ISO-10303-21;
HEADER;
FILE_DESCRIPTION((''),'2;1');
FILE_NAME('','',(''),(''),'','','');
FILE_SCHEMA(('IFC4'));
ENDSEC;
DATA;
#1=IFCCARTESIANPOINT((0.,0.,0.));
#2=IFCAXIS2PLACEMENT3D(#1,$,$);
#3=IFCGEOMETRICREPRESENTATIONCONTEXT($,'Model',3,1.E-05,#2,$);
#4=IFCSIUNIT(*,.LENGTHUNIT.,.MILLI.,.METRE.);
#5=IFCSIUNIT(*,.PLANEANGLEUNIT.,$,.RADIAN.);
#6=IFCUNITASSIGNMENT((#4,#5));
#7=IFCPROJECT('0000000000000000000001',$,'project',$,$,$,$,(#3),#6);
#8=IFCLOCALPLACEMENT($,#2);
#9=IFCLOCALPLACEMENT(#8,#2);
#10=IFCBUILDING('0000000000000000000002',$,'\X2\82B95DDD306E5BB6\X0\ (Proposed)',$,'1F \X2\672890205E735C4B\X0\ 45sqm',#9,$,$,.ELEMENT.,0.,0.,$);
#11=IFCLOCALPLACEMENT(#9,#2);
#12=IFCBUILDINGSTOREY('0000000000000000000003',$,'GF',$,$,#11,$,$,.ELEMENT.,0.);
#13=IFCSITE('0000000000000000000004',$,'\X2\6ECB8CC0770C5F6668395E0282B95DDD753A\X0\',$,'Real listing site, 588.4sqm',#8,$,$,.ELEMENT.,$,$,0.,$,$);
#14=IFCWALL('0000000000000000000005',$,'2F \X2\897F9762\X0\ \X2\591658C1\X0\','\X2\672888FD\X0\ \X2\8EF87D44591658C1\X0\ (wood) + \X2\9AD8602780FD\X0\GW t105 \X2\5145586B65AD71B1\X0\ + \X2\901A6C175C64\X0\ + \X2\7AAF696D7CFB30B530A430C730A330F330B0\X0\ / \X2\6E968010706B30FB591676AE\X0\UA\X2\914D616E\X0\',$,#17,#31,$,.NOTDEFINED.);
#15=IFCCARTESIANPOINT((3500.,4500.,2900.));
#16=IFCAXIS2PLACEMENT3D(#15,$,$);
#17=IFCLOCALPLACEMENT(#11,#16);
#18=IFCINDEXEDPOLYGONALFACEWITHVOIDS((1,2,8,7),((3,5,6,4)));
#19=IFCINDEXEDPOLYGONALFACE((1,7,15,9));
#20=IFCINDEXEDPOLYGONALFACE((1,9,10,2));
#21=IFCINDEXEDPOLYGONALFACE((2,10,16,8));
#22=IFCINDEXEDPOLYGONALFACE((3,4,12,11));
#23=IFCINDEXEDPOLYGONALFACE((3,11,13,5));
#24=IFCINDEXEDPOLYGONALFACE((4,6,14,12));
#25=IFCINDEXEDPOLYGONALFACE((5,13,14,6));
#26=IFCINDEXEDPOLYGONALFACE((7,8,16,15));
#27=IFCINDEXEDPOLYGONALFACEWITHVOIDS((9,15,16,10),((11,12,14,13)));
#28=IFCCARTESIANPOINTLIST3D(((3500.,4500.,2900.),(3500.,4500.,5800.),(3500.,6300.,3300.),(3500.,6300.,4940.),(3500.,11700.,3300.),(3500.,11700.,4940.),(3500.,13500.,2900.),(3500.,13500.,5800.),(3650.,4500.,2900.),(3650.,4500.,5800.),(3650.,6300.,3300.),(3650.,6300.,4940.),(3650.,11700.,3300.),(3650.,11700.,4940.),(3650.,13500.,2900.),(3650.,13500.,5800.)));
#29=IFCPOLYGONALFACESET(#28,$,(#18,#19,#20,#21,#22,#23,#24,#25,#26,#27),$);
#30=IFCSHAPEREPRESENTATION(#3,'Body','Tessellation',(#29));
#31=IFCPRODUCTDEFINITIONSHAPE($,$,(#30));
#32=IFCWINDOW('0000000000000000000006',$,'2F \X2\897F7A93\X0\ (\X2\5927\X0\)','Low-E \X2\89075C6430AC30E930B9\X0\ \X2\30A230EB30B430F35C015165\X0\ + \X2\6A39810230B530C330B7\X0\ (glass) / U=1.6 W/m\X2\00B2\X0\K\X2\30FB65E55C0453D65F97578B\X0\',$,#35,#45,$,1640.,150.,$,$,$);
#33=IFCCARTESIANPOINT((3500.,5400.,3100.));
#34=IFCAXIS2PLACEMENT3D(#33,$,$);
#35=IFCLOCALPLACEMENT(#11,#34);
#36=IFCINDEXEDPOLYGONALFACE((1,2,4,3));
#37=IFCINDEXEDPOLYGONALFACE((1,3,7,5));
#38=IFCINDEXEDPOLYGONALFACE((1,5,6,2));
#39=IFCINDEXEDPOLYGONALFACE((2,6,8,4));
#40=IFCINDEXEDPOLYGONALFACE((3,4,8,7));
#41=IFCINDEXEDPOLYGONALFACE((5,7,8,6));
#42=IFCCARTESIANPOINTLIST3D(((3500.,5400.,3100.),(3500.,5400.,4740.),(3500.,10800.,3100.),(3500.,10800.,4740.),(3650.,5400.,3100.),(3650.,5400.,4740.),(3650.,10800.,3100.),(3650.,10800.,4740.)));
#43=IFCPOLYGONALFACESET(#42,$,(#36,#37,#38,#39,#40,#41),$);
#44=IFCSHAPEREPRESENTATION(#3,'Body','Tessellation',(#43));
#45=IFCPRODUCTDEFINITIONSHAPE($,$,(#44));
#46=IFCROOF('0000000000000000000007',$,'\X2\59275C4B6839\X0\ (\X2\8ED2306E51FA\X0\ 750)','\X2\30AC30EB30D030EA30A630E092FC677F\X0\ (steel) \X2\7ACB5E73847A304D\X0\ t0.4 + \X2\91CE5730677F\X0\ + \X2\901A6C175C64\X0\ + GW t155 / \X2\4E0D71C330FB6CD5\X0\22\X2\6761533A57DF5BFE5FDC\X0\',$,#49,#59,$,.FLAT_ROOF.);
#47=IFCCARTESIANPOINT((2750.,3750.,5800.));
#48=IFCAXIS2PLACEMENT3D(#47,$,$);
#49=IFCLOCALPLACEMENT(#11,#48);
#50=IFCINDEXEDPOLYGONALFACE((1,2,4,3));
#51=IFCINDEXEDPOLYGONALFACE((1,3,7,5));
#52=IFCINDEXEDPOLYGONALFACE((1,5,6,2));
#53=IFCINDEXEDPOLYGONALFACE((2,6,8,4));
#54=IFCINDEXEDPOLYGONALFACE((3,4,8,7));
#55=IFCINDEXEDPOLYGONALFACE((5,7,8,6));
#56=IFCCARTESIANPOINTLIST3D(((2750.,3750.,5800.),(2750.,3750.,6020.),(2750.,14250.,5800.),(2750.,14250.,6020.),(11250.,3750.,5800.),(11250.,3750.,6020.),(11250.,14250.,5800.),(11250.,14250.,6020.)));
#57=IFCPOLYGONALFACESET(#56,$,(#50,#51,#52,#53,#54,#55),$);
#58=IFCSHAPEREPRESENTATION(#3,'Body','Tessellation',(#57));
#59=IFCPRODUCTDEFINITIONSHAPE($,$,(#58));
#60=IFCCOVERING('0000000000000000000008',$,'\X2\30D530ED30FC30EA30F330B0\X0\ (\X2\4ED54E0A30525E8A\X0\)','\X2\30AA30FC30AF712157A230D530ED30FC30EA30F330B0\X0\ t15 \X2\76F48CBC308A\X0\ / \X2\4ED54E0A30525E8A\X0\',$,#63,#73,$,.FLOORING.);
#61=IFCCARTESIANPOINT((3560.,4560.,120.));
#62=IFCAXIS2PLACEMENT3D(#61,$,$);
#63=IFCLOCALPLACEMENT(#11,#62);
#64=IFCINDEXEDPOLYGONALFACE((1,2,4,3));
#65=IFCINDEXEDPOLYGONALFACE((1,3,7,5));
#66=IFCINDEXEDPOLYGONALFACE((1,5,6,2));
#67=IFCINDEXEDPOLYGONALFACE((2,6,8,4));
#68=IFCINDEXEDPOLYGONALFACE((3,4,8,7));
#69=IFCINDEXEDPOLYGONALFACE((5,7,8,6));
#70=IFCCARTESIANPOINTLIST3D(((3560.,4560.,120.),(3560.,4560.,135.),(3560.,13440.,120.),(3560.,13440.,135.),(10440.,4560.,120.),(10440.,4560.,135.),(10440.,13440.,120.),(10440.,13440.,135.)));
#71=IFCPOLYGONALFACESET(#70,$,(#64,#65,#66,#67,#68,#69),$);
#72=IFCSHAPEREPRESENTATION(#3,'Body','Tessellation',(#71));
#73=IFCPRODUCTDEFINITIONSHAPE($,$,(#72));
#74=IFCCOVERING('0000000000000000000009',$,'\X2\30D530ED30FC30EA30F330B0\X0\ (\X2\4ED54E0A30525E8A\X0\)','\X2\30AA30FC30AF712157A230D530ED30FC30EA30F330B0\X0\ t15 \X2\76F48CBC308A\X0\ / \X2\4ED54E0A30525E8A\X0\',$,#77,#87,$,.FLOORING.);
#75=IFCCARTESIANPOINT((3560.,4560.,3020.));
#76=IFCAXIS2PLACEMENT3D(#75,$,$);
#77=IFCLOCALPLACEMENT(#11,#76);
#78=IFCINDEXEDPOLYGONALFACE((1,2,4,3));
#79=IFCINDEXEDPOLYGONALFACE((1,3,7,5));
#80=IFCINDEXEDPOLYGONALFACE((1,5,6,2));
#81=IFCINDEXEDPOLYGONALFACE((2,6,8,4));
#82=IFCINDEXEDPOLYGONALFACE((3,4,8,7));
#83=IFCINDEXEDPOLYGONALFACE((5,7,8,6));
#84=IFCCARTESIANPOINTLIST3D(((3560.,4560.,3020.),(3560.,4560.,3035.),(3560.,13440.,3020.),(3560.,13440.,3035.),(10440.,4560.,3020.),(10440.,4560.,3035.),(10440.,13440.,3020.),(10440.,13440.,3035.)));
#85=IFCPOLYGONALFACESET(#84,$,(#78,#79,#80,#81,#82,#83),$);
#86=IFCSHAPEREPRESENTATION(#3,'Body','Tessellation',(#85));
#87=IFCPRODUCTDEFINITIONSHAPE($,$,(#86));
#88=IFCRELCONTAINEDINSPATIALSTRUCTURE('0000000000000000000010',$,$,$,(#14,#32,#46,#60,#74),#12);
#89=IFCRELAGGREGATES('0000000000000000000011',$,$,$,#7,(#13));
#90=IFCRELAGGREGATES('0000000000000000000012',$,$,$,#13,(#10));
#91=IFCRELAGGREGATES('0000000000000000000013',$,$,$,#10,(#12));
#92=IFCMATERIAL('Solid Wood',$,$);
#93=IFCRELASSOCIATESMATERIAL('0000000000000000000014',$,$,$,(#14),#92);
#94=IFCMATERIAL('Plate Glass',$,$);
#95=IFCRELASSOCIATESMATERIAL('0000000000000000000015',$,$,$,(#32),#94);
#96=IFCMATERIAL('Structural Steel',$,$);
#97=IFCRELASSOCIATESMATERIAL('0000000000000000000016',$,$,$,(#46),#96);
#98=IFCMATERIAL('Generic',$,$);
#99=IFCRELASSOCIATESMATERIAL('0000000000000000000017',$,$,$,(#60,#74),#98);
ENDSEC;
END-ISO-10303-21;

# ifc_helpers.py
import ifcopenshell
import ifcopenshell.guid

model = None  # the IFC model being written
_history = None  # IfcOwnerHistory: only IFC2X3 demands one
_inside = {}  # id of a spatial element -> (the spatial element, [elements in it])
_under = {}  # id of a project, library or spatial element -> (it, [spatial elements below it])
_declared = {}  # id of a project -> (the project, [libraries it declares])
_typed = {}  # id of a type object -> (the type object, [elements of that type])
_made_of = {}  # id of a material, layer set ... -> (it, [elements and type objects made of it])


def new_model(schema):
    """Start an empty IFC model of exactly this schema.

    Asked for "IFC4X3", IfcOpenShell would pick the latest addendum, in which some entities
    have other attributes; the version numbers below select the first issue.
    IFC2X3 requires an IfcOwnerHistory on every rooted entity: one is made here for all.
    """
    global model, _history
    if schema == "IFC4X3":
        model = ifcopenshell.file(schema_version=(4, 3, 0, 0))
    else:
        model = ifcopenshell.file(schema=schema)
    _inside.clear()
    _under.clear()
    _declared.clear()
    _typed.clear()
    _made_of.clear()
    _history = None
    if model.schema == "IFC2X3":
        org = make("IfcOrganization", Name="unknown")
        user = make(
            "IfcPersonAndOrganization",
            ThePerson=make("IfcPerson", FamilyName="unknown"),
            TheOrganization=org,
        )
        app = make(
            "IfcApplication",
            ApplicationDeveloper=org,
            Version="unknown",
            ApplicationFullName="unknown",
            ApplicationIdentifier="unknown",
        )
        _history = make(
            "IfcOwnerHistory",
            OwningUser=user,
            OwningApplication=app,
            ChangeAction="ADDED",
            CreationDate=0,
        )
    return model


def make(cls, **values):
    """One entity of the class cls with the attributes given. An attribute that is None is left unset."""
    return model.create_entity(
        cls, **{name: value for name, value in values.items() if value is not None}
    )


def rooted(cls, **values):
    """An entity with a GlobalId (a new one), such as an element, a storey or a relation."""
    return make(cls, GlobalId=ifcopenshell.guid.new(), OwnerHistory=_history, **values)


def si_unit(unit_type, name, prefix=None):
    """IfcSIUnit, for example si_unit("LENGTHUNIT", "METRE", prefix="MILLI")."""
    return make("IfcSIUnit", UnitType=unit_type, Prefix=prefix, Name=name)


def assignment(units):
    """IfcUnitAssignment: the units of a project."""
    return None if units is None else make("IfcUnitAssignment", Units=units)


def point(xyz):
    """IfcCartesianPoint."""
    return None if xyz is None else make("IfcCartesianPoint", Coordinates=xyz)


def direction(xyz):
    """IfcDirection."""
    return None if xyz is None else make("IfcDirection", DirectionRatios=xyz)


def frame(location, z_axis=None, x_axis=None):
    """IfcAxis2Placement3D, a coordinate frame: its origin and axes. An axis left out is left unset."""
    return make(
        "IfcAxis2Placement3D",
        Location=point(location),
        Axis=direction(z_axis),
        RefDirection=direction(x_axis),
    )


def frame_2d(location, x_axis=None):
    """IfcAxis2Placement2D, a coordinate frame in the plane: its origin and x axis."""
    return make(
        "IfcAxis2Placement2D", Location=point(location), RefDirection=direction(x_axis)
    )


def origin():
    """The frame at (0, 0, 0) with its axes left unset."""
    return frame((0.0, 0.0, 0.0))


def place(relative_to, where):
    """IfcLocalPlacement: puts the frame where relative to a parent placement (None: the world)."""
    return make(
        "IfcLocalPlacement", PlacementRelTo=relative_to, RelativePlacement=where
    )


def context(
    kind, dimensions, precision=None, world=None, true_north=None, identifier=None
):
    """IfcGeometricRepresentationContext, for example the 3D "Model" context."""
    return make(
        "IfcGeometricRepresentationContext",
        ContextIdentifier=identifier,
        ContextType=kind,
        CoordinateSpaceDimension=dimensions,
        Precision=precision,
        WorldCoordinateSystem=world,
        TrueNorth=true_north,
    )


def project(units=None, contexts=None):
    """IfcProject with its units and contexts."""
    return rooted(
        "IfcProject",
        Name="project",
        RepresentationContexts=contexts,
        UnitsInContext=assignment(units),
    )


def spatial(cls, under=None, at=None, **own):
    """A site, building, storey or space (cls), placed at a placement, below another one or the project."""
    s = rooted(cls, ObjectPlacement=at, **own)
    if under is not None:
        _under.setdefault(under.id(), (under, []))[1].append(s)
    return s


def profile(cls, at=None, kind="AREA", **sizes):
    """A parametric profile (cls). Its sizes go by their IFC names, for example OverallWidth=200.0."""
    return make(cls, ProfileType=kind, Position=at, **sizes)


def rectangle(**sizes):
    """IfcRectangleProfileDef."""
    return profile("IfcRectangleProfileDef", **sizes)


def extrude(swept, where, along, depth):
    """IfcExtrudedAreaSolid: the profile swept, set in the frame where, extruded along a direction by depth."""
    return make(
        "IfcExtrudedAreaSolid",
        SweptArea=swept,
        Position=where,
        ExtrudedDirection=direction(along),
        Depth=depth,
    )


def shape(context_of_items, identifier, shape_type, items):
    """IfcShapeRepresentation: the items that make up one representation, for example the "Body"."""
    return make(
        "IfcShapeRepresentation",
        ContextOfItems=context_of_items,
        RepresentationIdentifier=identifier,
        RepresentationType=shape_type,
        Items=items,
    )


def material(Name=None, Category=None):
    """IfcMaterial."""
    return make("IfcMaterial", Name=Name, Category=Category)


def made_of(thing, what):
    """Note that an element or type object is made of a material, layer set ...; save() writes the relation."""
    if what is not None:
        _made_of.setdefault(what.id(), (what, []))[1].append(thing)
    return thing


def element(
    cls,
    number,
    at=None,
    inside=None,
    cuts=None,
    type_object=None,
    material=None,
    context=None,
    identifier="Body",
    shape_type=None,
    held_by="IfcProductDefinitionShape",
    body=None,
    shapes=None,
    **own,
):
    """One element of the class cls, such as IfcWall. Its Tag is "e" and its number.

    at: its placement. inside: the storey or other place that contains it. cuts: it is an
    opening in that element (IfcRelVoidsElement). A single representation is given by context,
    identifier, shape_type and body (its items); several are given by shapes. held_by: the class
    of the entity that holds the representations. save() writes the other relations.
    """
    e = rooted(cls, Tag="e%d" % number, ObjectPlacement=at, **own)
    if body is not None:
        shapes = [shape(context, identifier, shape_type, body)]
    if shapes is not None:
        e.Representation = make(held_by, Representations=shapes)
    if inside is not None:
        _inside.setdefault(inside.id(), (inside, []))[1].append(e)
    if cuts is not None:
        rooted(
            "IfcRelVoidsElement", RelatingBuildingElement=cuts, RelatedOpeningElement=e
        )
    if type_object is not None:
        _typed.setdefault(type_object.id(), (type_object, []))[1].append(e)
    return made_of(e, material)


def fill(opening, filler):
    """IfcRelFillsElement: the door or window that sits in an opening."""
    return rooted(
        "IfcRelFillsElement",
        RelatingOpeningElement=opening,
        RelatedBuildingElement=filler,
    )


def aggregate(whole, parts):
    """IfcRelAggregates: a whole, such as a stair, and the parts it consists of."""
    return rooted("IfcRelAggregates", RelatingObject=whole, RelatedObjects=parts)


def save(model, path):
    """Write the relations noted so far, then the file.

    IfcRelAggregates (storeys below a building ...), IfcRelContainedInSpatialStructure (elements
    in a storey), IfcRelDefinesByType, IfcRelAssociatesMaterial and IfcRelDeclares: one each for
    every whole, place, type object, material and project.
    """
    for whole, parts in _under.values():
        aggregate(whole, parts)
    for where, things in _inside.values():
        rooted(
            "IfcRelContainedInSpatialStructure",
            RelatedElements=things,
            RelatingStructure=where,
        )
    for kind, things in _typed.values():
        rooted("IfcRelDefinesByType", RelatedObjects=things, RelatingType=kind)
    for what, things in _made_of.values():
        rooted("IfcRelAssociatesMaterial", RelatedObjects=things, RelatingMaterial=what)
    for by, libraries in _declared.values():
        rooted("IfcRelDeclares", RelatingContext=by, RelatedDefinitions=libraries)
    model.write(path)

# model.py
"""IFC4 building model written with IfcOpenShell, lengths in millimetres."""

from ifc_helpers import new_model, si_unit, frame, frame_2d, origin, place, context, project, spatial, rectangle, extrude, material, element, fill, save


model = new_model("IFC4")

# Units and contexts
model_context = context("Model", 3, precision=1e-05, world=origin())
ifc_project = project(units=[si_unit("LENGTHUNIT", "METRE", prefix="MILLI"), si_unit("PLANEANGLEUNIT", "RADIAN")], contexts=[model_context])

# Site, building, storey
site_placement = place(None, origin())
site = spatial("IfcSite", under=ifc_project, at=site_placement, Name="滋賀県彦根市芹川町", ObjectType="Real listing site, 588.4sqm", CompositionType="ELEMENT", RefElevation=0.0)
building_placement = place(site_placement, origin())
building = spatial("IfcBuilding", under=site, at=building_placement, Name="芹川の家 (Proposed)", ObjectType="1F 木造平屋 45sqm", CompositionType="ELEMENT", ElevationOfRefHeight=0.0, ElevationOfTerrain=0.0)
storey_placement = place(building_placement, origin())
storey = spatial("IfcBuildingStorey", under=building, at=storey_placement, Name="GF", CompositionType="ELEMENT", Elevation=0.0)

# Shared definitions
ifc_material_1 = material(Name="Solid Wood")
ifc_material_2 = material(Name="Generic")

# Shared definitions
ifc_material_3 = material(Name="Plate Glass")

# Wall, opening, window
wall_1_placement = place(storey_placement, frame((3500.0, 4500.0, 2900.0)))
wall_1 = element("IfcWall", 1, at=wall_1_placement, inside=storey, material=ifc_material_1, Name="2F 西面 外壁", Description="木製 軸組外壁 (wood) + 高性能GW t105 充填断熱 + 通気層 + 窯業系サイディング / 準耐火・外皮UA配慮", PredefinedType="NOTDEFINED", context=model_context, shape_type="SweptSolid", body=[
    extrude(rectangle(XDim=150.0, YDim=9000.0, at=frame_2d((75.0, 4500.0))), frame((3500.0, 4500.0, 2900.0)), (0.0, 0.0, 1.0), 2900.0),
])
opening_1_placement = place(storey_placement, frame((3500.0, 5400.0, 3100.0)))
opening_1 = element("IfcOpeningElement", 2, at=opening_1_placement, cuts=wall_1, PredefinedType="NOTDEFINED", context=model_context, shape_type="SweptSolid", body=[
    extrude(rectangle(XDim=150.0, YDim=5400.0, at=frame_2d((75.0, 2700.0))), frame((3500.0, 5400.0, 3100.0)), (0.0, 0.0, 1.0), 1640.0),
])
window_1_placement = place(storey_placement, frame((3500.0, 5400.0, 3100.0)))
window_1 = element("IfcWindow", 3, at=window_1_placement, inside=storey, material=ifc_material_3, Name="2F 西窓 (大)", Description="Low-E 複層ガラス アルゴン封入 + 樹脂サッシ (glass) / U=1.6 W/m²K・日射取得型", OverallHeight=1640.0, OverallWidth=150.0, context=model_context, shape_type="SweptSolid", body=[
    extrude(rectangle(XDim=150.0, YDim=5400.0, at=frame_2d((75.0, 2700.0))), frame((3500.0, 5400.0, 3100.0)), (0.0, 0.0, 1.0), 1640.0),
])
fill(opening_1, window_1)

# Roof
ifc_material_4 = material(Name="Structural Steel")
roof_placement = place(storey_placement, frame((2750.0, 3750.0, 5800.0)))
element("IfcRoof", 4, at=roof_placement, inside=storey, material=ifc_material_4, Name="大屋根 (軒の出 750)", Description="ガルバリウム鋼板 (steel) 立平葺き t0.4 + 野地板 + 通気層 + GW t155 / 不燃・法22条区域対応", PredefinedType="FLAT_ROOF", context=model_context, shape_type="SweptSolid", body=[
    extrude(rectangle(XDim=8500.0, YDim=10500.0, at=frame_2d((4250.0, 5250.0))), frame((2750.0, 3750.0, 5800.0)), (0.0, 0.0, 1.0), 220.0),
])

# Coverings
covering_1_placement = place(storey_placement, frame((3560.0, 4560.0, 120.0)))
element("IfcCovering", 5, at=covering_1_placement, inside=storey, material=ifc_material_2, Name="フローリング (仕上げ床)", Description="オーク無垢フローリング t15 直貼り / 仕上げ床", PredefinedType="FLOORING", context=model_context, shape_type="SweptSolid", body=[
    extrude(rectangle(XDim=6880.0, YDim=8880.0, at=frame_2d((3440.0, 4440.0))), frame((3560.0, 4560.0, 120.0)), (0.0, 0.0, 1.0), 15.0),
])
covering_2_placement = place(storey_placement, frame((3560.0, 4560.0, 3020.0)))
element("IfcCovering", 6, at=covering_2_placement, inside=storey, material=ifc_material_2, Name="フローリング (仕上げ床)", Description="オーク無垢フローリング t15 直貼り / 仕上げ床", PredefinedType="FLOORING", context=model_context, shape_type="SweptSolid", body=[
    extrude(rectangle(XDim=6880.0, YDim=8880.0, at=frame_2d((3440.0, 4440.0))), frame((3560.0, 4560.0, 3020.0)), (0.0, 0.0, 1.0), 15.0),
])

save(model, "model.ifc")
